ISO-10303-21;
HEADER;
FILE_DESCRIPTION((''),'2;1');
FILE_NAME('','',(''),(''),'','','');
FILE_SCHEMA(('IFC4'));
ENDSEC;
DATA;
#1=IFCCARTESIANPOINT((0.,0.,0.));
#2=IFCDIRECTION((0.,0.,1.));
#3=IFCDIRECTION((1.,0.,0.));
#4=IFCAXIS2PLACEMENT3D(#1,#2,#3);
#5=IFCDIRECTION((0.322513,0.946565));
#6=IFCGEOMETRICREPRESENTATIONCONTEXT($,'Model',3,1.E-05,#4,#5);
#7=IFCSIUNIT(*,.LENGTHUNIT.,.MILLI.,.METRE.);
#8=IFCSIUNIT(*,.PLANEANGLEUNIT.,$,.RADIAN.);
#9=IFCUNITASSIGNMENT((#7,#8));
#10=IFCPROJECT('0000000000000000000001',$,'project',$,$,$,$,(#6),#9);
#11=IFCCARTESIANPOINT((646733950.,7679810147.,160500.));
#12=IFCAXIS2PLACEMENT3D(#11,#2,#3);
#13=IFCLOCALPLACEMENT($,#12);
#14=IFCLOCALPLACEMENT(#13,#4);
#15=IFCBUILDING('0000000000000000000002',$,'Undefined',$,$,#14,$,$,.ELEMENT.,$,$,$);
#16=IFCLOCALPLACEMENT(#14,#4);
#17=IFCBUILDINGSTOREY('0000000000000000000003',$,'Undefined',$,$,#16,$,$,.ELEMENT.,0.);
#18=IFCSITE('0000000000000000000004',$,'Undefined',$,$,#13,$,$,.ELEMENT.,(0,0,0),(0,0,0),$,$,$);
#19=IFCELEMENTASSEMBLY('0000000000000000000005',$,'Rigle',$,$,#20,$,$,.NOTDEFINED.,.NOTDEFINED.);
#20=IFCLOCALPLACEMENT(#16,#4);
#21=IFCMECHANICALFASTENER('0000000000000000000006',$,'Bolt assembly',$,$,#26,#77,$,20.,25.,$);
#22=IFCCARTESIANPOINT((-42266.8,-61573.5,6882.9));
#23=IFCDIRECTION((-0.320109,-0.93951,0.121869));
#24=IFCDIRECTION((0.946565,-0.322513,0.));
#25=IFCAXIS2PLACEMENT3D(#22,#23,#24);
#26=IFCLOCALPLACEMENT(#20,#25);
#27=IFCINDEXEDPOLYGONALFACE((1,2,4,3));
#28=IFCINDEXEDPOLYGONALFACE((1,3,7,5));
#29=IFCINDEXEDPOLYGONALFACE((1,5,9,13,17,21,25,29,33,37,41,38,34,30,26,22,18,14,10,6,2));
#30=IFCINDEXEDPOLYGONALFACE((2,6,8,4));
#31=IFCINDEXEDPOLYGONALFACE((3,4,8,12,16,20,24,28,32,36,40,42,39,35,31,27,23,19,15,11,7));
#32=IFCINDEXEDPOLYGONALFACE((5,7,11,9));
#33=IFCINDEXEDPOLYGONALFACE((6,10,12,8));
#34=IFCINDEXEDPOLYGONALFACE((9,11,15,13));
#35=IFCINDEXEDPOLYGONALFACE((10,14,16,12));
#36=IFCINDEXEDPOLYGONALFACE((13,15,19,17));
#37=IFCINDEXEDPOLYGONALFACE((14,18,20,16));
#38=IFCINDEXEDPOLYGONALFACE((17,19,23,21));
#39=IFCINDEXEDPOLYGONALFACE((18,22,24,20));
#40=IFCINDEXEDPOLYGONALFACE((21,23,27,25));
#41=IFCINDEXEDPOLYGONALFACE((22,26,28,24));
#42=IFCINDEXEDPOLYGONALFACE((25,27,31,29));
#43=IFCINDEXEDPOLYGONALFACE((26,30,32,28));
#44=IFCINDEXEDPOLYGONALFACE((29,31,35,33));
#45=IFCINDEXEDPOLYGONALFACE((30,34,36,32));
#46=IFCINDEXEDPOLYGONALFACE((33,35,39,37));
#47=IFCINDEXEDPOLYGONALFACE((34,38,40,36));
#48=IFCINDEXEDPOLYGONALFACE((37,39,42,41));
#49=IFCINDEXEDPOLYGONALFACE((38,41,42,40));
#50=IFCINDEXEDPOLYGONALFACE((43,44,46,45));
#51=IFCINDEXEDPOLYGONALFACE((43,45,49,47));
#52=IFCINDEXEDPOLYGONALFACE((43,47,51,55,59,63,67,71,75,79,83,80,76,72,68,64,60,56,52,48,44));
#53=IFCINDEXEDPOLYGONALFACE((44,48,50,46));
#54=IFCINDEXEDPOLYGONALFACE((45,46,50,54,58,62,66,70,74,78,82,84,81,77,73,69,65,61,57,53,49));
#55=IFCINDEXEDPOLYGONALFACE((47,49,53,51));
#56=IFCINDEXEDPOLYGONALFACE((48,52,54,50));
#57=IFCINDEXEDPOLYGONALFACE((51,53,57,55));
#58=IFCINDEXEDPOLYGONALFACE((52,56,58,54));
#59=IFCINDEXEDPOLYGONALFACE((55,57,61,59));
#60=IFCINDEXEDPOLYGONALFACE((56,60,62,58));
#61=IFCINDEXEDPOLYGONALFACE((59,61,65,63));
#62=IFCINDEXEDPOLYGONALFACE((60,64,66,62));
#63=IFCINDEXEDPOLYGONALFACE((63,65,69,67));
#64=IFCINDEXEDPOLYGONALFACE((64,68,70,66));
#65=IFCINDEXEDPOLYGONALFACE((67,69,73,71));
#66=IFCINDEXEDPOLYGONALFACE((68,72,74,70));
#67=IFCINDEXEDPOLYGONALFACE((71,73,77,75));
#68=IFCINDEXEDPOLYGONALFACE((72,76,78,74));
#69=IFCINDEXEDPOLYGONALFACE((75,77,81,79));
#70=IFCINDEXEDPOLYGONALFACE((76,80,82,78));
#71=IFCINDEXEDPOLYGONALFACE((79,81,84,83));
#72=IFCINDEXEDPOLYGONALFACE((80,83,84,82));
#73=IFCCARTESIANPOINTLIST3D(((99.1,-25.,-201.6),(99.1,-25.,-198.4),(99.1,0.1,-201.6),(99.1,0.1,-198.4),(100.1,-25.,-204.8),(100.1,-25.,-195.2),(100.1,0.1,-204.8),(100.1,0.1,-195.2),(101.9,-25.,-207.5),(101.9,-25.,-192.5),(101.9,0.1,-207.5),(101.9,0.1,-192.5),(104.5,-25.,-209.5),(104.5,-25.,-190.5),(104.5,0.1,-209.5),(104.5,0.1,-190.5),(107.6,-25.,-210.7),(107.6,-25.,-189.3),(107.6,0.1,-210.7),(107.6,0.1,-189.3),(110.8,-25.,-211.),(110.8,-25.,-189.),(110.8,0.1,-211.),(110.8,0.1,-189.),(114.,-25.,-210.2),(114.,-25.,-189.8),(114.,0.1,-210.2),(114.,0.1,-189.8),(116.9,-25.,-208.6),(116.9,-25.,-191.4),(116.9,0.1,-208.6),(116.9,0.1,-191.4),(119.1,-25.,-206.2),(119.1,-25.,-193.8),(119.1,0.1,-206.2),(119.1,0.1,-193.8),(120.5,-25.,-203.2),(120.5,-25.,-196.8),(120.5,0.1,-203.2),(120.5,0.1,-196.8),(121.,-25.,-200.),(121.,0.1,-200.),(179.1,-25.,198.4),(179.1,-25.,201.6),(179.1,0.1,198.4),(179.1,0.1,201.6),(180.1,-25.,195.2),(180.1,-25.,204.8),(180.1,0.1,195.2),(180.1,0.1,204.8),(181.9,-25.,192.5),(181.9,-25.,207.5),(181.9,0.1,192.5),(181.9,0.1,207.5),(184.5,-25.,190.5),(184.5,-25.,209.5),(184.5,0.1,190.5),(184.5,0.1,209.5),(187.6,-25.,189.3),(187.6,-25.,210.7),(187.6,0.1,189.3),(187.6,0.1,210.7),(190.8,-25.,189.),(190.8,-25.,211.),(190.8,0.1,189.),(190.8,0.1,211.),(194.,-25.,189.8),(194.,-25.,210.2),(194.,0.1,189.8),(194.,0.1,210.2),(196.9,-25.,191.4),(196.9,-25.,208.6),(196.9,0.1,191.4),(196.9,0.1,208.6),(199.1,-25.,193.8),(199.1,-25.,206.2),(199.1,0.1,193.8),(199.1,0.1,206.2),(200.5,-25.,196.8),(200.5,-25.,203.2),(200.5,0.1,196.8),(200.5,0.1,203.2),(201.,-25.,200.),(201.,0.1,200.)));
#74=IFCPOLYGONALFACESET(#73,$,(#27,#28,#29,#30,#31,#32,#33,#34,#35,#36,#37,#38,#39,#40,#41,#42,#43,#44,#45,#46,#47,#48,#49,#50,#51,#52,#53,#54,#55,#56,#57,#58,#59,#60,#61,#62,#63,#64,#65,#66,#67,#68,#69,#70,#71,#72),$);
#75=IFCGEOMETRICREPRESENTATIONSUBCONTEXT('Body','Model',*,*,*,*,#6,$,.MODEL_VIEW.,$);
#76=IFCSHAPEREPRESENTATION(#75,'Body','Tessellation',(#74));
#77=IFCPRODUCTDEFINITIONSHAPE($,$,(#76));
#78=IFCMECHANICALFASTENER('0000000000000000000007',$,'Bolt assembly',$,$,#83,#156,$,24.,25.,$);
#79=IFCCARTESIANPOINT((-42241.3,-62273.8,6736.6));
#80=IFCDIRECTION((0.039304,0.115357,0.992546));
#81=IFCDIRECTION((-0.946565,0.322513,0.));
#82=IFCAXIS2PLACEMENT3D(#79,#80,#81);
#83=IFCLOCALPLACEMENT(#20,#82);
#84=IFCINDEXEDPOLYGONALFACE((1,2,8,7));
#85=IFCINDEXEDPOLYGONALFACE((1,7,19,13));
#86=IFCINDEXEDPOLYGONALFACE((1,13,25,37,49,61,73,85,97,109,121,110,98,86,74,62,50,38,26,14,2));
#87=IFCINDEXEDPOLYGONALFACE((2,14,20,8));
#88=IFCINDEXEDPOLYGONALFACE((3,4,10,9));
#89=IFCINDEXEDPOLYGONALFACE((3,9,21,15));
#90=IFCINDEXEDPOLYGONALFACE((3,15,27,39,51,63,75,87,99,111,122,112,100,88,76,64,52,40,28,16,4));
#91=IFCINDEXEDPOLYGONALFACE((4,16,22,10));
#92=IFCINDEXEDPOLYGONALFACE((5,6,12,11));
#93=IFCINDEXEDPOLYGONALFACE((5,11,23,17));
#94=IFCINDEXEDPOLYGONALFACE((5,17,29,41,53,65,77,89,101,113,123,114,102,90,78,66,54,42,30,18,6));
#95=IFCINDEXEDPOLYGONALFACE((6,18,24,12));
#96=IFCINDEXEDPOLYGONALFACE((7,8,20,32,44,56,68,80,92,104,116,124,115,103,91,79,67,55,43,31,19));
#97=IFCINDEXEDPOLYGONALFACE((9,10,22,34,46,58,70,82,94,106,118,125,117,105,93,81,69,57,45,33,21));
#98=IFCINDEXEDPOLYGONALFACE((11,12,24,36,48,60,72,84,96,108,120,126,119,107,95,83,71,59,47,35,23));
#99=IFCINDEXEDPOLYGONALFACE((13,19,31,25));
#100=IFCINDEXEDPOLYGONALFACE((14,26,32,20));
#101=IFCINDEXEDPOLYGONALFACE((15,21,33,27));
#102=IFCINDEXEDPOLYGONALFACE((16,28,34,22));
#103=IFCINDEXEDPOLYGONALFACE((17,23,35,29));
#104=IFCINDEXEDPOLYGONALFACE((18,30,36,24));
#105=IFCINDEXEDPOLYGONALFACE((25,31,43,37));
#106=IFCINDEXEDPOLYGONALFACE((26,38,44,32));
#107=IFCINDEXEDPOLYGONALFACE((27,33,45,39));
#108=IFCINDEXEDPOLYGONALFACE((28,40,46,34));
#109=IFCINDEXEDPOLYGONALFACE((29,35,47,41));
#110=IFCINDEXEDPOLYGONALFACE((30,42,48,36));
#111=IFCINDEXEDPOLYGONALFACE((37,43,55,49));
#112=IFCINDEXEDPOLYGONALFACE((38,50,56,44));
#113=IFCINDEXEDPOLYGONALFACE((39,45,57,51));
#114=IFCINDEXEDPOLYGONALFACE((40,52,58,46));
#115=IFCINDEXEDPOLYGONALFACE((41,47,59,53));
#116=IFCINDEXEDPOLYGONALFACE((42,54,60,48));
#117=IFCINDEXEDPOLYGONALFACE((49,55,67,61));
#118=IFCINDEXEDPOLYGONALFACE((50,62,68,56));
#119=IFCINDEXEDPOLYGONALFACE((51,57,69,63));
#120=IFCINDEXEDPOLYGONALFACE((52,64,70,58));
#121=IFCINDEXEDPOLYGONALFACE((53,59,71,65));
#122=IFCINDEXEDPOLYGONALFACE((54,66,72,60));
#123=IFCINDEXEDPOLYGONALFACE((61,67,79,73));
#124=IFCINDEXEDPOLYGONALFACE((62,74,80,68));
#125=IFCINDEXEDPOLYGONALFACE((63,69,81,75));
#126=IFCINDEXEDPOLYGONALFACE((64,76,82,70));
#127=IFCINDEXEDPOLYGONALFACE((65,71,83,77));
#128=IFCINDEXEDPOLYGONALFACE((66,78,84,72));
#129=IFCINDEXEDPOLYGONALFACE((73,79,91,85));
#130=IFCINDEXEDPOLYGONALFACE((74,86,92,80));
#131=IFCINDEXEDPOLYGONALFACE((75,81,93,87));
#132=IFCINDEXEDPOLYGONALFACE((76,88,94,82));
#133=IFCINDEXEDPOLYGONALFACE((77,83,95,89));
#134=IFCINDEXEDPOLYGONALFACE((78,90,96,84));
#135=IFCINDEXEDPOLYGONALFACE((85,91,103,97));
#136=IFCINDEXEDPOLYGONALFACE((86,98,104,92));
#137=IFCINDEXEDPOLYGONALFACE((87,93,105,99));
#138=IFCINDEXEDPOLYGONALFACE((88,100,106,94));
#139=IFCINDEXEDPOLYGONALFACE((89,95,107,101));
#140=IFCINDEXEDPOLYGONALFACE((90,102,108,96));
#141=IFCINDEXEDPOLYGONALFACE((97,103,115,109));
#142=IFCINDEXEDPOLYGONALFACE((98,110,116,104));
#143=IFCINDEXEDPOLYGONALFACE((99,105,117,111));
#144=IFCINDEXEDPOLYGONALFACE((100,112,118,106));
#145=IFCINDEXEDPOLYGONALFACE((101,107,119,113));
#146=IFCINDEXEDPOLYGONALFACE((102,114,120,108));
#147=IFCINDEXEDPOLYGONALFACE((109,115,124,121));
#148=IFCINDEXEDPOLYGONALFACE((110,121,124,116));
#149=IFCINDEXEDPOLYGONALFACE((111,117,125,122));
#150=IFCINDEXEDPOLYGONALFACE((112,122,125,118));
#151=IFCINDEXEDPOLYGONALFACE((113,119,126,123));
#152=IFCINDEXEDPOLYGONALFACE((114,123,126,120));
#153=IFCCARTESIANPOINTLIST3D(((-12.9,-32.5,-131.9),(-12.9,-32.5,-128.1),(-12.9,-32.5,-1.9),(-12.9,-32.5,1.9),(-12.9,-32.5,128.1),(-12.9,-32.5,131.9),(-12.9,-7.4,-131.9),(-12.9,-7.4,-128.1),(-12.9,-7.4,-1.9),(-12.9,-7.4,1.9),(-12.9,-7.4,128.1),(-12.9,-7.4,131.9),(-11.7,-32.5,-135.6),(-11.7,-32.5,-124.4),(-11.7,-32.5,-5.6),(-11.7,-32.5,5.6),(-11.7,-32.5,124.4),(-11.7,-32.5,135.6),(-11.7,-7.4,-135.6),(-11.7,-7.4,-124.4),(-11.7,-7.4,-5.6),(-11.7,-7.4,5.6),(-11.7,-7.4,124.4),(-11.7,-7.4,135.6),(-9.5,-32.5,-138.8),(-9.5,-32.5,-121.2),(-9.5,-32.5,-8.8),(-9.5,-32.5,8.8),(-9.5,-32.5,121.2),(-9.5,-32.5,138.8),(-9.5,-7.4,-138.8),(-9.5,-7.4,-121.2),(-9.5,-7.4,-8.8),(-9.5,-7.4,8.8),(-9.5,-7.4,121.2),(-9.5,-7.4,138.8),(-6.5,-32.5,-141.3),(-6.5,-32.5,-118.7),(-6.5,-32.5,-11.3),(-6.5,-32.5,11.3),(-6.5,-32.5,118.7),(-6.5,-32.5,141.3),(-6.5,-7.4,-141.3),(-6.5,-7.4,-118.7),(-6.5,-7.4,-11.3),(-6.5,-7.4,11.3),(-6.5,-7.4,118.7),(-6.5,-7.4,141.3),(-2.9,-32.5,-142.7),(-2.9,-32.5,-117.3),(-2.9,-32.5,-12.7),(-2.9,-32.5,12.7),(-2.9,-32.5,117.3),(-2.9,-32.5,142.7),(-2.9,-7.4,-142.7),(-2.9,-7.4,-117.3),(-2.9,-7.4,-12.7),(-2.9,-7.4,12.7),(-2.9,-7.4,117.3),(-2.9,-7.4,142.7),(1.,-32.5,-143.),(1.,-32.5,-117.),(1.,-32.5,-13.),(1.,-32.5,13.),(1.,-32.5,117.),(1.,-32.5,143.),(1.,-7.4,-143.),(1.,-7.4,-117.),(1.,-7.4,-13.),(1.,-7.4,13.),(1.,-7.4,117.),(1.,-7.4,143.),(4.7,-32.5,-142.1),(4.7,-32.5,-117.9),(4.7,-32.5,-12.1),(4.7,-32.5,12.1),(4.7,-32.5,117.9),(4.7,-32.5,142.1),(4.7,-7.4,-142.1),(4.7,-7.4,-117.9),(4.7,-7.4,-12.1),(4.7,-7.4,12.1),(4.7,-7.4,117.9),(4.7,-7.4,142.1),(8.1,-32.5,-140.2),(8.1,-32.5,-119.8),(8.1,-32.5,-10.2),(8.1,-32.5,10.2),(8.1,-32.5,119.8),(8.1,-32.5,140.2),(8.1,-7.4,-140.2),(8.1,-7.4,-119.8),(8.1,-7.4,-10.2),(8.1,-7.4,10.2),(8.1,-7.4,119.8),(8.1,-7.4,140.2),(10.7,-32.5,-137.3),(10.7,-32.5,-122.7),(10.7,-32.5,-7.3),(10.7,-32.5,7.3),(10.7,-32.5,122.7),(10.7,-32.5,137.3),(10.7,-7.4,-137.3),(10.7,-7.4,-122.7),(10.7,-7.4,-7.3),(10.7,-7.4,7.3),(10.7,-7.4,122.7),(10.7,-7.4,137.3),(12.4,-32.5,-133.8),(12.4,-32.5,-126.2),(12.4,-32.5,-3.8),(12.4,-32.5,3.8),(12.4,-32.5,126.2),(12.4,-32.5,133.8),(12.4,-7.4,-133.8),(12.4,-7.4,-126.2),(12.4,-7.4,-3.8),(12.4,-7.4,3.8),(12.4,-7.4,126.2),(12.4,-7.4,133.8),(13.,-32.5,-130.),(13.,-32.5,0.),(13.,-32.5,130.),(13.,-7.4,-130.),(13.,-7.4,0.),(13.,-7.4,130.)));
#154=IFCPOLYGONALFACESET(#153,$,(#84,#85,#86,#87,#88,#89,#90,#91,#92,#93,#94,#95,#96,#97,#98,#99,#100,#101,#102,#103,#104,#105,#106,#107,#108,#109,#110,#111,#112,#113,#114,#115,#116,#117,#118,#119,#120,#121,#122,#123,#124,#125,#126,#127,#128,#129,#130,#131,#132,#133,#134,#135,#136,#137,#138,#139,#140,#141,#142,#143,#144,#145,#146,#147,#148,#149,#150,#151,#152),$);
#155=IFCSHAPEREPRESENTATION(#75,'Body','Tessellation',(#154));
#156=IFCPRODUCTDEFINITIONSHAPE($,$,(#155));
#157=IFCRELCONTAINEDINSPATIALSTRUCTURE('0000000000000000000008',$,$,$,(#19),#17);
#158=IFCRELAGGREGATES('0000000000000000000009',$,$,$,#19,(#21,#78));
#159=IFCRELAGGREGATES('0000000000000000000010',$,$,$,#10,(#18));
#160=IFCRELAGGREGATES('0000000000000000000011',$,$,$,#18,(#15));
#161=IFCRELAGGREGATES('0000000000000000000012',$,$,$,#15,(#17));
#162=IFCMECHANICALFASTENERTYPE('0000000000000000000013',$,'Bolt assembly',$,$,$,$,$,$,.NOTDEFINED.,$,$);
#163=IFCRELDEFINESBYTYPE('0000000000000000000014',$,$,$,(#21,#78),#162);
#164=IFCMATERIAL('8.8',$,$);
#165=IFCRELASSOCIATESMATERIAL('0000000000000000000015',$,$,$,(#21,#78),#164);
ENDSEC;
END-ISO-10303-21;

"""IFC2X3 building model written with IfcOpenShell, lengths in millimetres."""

from ifc_helpers import new_model, si_unit, direction, frame, origin_with_axes, origin_2d_with_axis, place, context, subcontext, project, spatial, circle, extrude, source, transform, mapped, material, type_object, element, aggregate, save


model = new_model("IFC2X3")

# Units and contexts
model_context = context("Model", 3, precision=1e-05, world=origin_with_axes(), true_north=direction((0.322513, 0.946565)))
body_context = subcontext(model_context, "Body", "Model", "MODEL_VIEW")
ifc_project = project(units=[si_unit("LENGTHUNIT", "METRE", prefix="MILLI"), si_unit("PLANEANGLEUNIT", "RADIAN")], contexts=[model_context])

# Site, building, storey
site_placement = place(None, frame((646733950.0, 7679810147.0, 160500.0), z_axis=(0.0, 0.0, 1.0), x_axis=(1.0, 0.0, 0.0)))
site = spatial("IfcSite", under=ifc_project, at=site_placement, Name="Undefined", CompositionType="ELEMENT", RefLatitude=(0, 0, 0), RefLongitude=(0, 0, 0))
building_placement = place(site_placement, origin_with_axes())
building = spatial("IfcBuilding", under=site, at=building_placement, Name="Undefined", CompositionType="ELEMENT")
storey_placement = place(building_placement, origin_with_axes())
storey = spatial("IfcBuildingStorey", under=building, at=storey_placement, Name="Undefined", CompositionType="ELEMENT", Elevation=0.0)

# Element assembly
assembly_1_placement = place(storey_placement, origin_with_axes())
assembly_1 = element("IfcElementAssembly", 1, at=assembly_1_placement, inside=storey, Name="Rigle", AssemblyPlace="NOTDEFINED", PredefinedType="NOTDEFINED")

# Mechanical fastener
ifc_material_1 = material(Name="8.8")
mechanical_fastener_type = type_object("IfcMechanicalFastenerType", Name="Bolt assembly")
shared_shape_1 = source(origin_with_axes(), body_context, "Body", "SweptSolid", [
    extrude(circle(Radius=11.0, at=origin_2d_with_axis()), frame((0.0, -25.0, 0.0), z_axis=(0.0, 1.0, 0.0), x_axis=(1.0, 0.0, 0.0)), (0.0, 0.0, 1.0), 25.1),
])
mechanical_fastener_1_placement = place(assembly_1_placement, frame((-42266.8, -61573.5, 6882.9), z_axis=(-0.320109, -0.93951, 0.121869), x_axis=(0.946565, -0.322513, 0.0)))
mechanical_fastener_1 = element("IfcMechanicalFastener", 2, at=mechanical_fastener_1_placement, type_object=mechanical_fastener_type, material=ifc_material_1, Name="Bolt assembly", NominalDiameter=20.0, NominalLength=25.0, context=body_context, shape_type="MappedRepresentation", body=[
    mapped(shared_shape_1, transform((110.0, 0.0, -200.0))),
    mapped(shared_shape_1, transform((190.0, 0.0, 200.0))),
])

# Mechanical fastener
shared_shape_2 = source(origin_with_axes(), body_context, "Body", "SweptSolid", [
    extrude(circle(Radius=13.0, at=origin_2d_with_axis()), frame((0.0, -32.5, 0.0), z_axis=(0.0, 1.0, 0.0), x_axis=(1.0, 0.0, 0.0)), (0.0, 0.0, 1.0), 25.1),
])
mechanical_fastener_2_placement = place(assembly_1_placement, frame((-42241.3, -62273.8, 6736.6), z_axis=(0.039304, 0.115357, 0.992546), x_axis=(-0.946565, 0.322513, 0.0)))
mechanical_fastener_2 = element("IfcMechanicalFastener", 3, at=mechanical_fastener_2_placement, type_object=mechanical_fastener_type, material=ifc_material_1, Name="Bolt assembly", NominalDiameter=24.0, NominalLength=25.0, context=body_context, shape_type="MappedRepresentation", body=[
    mapped(shared_shape_2, transform((0.0, 0.0, -130.0))),
    mapped(shared_shape_2, transform((0.0, 0.0, 0.0))),
    mapped(shared_shape_2, transform((0.0, 0.0, 130.0))),
])
aggregate(assembly_1, [mechanical_fastener_1, mechanical_fastener_2])

save(model, "model.ifc")
